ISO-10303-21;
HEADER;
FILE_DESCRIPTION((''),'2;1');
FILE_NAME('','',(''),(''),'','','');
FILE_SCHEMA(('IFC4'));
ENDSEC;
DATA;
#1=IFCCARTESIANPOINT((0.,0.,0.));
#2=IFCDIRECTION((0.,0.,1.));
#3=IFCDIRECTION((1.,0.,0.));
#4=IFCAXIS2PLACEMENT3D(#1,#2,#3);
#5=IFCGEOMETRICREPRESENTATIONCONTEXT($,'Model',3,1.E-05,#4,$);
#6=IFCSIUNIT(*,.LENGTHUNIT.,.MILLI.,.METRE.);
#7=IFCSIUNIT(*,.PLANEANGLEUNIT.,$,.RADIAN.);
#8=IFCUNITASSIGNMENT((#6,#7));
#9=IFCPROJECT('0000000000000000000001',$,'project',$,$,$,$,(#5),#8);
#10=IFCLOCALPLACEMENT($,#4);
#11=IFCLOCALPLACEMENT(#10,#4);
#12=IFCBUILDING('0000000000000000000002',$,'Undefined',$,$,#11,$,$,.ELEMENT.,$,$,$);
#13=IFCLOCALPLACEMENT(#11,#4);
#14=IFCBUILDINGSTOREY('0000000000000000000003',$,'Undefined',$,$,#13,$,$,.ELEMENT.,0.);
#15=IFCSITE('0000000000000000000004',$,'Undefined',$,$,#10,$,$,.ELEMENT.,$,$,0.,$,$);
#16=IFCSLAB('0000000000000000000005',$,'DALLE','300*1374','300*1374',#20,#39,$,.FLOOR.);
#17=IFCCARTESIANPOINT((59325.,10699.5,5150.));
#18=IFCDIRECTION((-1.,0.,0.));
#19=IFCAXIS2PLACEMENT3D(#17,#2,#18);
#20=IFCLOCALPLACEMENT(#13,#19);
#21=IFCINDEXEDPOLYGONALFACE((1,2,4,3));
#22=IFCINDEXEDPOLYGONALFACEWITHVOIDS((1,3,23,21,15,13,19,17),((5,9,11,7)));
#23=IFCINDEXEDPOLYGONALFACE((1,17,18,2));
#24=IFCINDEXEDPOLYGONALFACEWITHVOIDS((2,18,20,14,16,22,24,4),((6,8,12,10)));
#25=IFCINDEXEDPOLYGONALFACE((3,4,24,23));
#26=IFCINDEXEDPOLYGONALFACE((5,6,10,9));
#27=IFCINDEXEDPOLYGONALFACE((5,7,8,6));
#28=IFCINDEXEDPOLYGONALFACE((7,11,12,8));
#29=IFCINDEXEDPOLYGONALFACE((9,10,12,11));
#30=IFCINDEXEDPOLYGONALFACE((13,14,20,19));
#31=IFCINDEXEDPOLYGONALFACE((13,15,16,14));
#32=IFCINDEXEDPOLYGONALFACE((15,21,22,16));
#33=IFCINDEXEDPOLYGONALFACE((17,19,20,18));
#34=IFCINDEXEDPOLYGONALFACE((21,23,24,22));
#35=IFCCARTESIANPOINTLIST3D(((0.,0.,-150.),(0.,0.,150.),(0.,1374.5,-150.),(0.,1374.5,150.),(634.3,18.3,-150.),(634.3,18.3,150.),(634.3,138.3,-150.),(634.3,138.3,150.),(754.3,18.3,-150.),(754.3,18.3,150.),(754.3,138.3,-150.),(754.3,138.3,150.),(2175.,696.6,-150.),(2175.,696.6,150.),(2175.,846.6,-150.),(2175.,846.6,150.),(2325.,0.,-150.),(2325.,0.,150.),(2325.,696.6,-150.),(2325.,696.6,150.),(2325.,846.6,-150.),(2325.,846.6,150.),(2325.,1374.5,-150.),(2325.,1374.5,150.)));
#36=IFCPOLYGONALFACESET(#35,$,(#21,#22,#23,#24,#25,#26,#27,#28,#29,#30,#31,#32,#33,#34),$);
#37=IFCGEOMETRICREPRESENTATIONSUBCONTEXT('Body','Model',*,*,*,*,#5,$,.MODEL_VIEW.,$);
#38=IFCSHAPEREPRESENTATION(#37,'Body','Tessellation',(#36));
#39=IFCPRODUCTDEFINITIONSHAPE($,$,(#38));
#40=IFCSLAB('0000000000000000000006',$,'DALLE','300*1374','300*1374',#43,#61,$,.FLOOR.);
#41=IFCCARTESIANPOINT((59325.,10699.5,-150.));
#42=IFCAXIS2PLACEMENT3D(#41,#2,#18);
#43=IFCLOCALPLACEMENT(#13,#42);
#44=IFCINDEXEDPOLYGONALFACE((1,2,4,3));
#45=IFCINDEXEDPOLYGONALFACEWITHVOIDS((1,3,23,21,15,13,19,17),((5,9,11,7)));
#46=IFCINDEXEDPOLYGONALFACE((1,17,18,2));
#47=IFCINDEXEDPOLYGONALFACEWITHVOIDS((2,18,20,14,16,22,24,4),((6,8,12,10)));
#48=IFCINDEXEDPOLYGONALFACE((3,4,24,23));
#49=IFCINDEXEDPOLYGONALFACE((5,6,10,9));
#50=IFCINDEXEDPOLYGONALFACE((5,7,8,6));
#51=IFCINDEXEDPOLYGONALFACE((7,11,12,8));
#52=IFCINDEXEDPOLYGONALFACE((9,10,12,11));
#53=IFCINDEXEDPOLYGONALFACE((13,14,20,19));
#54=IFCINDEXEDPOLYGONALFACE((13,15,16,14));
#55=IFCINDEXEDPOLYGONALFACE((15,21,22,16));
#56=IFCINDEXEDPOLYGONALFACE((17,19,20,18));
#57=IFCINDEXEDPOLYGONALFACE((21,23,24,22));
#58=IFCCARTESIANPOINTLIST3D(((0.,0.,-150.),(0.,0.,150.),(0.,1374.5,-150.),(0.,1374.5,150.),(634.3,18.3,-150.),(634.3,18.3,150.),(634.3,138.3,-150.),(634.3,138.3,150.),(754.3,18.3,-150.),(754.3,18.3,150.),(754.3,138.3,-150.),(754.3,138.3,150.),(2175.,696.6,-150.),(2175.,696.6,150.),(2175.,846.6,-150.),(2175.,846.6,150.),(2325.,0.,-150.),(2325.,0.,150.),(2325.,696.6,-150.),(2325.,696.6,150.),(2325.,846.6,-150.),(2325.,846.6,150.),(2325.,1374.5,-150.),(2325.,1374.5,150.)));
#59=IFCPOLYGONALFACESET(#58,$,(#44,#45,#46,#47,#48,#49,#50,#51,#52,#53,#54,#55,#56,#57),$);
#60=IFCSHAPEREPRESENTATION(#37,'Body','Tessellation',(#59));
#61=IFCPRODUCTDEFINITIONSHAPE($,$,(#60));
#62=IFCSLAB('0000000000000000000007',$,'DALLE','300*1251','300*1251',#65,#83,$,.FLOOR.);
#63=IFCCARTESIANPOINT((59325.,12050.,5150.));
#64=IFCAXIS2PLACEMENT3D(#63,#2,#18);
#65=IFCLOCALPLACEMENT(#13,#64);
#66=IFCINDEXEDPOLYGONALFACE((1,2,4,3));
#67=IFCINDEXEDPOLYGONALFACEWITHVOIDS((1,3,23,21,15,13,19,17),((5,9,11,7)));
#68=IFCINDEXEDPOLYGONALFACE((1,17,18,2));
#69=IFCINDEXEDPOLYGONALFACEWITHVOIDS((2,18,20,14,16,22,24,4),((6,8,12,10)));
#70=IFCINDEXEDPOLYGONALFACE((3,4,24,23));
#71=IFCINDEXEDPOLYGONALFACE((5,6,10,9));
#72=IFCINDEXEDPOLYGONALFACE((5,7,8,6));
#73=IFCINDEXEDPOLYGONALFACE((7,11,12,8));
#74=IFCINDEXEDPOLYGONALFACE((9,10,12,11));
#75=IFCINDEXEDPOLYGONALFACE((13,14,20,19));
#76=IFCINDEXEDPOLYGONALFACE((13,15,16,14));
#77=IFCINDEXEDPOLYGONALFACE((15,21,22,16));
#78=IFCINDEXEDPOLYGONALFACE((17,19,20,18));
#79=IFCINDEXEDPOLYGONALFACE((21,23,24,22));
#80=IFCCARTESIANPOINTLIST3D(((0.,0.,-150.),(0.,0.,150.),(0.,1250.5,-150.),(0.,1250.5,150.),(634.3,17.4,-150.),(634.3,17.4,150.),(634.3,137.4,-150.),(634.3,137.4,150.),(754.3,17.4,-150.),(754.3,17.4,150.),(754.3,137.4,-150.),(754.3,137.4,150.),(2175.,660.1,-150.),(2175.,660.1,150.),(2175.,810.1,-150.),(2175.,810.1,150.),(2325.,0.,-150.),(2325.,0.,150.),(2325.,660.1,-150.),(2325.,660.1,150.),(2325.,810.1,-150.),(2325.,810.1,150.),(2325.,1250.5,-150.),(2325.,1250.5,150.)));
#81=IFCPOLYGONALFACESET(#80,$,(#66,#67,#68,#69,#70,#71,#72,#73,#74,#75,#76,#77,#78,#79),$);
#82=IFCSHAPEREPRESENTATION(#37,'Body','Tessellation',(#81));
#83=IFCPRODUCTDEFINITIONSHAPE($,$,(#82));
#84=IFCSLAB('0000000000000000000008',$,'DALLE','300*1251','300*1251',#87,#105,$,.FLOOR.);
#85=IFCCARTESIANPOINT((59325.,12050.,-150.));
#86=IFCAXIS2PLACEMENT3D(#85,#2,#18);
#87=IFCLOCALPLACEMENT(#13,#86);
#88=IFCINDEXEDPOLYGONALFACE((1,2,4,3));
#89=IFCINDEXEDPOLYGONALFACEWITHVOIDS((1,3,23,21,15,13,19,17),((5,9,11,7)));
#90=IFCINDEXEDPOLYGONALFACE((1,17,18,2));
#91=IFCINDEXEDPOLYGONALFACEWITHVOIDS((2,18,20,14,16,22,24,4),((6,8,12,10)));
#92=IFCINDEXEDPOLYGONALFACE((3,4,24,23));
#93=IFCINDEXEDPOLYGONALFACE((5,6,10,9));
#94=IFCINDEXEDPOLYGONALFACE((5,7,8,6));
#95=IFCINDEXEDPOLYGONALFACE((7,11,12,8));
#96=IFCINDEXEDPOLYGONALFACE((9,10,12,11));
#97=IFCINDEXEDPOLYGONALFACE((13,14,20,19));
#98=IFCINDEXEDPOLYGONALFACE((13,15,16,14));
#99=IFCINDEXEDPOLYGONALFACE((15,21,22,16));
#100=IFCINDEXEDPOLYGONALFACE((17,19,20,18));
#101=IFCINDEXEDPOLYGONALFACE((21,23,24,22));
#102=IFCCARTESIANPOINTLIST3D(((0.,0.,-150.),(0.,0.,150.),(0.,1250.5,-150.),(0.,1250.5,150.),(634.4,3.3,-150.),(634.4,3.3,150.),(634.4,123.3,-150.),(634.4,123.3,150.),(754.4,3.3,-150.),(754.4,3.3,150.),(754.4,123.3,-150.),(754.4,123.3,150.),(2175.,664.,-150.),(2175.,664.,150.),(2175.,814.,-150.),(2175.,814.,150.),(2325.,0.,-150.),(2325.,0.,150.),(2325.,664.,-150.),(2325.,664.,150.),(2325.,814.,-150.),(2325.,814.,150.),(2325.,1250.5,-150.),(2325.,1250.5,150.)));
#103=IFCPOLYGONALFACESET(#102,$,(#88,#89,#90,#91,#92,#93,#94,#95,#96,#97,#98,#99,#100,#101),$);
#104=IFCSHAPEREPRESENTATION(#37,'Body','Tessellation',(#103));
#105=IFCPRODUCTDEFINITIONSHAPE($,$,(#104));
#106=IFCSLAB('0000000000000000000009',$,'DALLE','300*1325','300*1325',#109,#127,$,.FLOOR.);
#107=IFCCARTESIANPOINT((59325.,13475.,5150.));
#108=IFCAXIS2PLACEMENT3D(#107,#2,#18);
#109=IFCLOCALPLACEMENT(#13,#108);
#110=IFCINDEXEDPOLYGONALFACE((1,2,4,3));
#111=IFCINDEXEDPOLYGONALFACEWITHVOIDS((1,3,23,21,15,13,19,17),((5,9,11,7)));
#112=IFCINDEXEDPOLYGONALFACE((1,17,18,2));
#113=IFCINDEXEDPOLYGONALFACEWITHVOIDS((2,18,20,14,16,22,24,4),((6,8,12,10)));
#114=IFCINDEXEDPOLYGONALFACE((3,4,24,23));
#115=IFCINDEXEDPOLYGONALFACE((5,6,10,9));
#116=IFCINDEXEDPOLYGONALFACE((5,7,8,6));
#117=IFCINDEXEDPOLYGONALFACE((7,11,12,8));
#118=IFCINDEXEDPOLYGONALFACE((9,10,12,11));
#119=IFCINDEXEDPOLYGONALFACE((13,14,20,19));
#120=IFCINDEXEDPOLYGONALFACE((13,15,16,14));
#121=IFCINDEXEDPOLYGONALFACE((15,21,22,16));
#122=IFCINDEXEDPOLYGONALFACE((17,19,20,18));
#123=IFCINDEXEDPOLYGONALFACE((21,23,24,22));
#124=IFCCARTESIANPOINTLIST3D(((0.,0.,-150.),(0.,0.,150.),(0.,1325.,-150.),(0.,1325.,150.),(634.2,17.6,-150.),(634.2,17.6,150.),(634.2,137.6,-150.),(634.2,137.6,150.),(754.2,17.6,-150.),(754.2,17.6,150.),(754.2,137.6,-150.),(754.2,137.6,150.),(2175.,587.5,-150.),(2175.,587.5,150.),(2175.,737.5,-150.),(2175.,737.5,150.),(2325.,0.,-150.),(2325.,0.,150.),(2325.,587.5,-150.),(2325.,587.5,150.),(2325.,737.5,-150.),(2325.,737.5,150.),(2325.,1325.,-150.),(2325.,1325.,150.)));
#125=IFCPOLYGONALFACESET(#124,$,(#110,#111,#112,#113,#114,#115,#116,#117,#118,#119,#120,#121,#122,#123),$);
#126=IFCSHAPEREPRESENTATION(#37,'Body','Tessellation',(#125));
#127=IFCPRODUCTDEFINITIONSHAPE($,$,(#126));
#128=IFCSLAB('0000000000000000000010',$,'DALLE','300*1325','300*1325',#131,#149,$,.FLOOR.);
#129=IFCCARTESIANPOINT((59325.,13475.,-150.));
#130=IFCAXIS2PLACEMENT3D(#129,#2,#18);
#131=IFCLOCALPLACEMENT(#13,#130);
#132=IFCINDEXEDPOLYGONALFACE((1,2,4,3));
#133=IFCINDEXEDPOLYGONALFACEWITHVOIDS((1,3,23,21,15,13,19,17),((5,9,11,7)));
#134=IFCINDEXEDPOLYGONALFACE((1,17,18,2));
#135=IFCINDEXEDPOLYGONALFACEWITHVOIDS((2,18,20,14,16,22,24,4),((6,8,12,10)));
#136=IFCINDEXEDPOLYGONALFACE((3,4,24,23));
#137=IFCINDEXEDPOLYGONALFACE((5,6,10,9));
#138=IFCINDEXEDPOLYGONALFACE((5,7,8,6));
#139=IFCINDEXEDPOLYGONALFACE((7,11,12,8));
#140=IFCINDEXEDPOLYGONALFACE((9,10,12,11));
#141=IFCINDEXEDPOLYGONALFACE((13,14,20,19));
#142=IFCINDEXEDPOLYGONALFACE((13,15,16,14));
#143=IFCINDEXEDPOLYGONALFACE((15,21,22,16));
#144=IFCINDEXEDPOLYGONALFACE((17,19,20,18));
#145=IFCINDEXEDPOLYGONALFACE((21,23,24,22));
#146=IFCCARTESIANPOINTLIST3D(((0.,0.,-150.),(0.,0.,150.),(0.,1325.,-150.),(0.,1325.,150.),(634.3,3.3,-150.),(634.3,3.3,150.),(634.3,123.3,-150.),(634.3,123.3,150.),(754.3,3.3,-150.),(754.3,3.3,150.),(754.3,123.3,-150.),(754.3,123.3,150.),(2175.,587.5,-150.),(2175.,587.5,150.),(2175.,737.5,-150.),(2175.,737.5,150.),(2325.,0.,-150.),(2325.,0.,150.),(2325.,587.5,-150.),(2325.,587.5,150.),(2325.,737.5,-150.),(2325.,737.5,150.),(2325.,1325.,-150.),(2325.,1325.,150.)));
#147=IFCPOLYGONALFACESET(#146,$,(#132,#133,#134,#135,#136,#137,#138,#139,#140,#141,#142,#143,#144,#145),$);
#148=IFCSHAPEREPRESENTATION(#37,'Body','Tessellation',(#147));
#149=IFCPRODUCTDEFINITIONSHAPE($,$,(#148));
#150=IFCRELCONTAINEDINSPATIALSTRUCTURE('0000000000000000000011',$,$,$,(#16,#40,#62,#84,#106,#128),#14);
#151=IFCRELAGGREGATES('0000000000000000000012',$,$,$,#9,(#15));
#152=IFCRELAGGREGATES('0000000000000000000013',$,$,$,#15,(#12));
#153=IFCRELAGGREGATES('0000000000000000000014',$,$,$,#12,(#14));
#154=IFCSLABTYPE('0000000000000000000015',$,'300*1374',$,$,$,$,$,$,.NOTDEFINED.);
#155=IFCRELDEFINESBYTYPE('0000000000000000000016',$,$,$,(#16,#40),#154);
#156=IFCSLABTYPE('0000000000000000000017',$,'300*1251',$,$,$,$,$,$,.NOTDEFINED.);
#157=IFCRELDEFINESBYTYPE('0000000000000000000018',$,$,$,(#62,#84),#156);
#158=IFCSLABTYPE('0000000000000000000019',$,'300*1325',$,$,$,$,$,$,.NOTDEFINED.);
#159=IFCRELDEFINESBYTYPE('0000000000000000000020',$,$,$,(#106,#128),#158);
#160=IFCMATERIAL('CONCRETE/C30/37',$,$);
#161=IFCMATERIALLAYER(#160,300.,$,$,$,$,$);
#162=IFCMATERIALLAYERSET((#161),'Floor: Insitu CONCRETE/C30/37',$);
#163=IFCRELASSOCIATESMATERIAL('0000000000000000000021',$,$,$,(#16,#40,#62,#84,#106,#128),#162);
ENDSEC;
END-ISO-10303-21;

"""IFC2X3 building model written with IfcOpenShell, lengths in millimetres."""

from ifc_helpers import new_model, si_unit, frame, origin_with_axes, origin_2d_with_axis, place, context, subcontext, project, spatial, polyline, rectangle, outline, extrude, boolean, material, layer, layer_set, layer_usage, type_object, element, save


model = new_model("IFC2X3")

# Units and contexts
model_context = context("Model", 3, precision=1e-05, world=origin_with_axes())
body_context = subcontext(model_context, "Body", "Model", "MODEL_VIEW")
ifc_project = project(units=[si_unit("LENGTHUNIT", "METRE", prefix="MILLI"), si_unit("PLANEANGLEUNIT", "RADIAN")], contexts=[model_context])

# Site, building, storey
site_placement = place(None, origin_with_axes())
site = spatial("IfcSite", under=ifc_project, at=site_placement, Name="Undefined", CompositionType="ELEMENT", RefElevation=0.0)
building_placement = place(site_placement, origin_with_axes())
building = spatial("IfcBuilding", under=site, at=building_placement, Name="Undefined", CompositionType="ELEMENT")
storey_placement = place(building_placement, origin_with_axes())
storey = spatial("IfcBuildingStorey", under=building, at=storey_placement, Name="Undefined", CompositionType="ELEMENT", Elevation=0.0)

# Slabs
ifc_material_1 = material(Name="CONCRETE/C30/37")
ifc_layer_1 = layer(ifc_material_1, 300.0)
ifc_layer_set_1 = layer_set([ifc_layer_1], Name="Floor: Insitu CONCRETE/C30/37")
ifc_layer_usage_1 = layer_usage(ifc_layer_set_1, "AXIS3", "POSITIVE", -150.0)
slab_type_1 = type_object("IfcSlabType", Name="300*1374", PredefinedType="NOTDEFINED")
slab_1_placement = place(storey_placement, frame((59325.0, 10699.5, 5150.0), z_axis=(0.0, 0.0, 1.0), x_axis=(-1.0, 0.0, 0.0)))
element("IfcSlab", 1, at=slab_1_placement, inside=storey, type_object=slab_type_1, material=ifc_layer_usage_1, Name="DALLE", Description="300*1374", ObjectType="300*1374", PredefinedType="FLOOR", context=body_context, shape_type="CSG", body=[
    boolean("DIFFERENCE", boolean("DIFFERENCE", extrude(outline(polyline([(0.0, 0.0), (2325.0, 0.0), (2325.0, 1374.5), (0.0, 1374.5), (0.0, 0.0)])), frame((0.0, 0.0, -150.0), z_axis=(0.0, 0.0, 1.0), x_axis=(1.0, 0.0, 0.0)), (0.0, 0.0, 1.0), 300.0), extrude(rectangle(XDim=150.0, YDim=150.0, at=origin_2d_with_axis()), frame((2250.0, 771.6, 160.0), z_axis=(0.0, 0.0, -1.0), x_axis=(-1.0, 0.0, 0.0)), (0.0, 0.0, 1.0), 320.0)), extrude(rectangle(XDim=120.0, YDim=120.0, at=origin_2d_with_axis()), frame((694.3, 78.3, 160.0), z_axis=(0.0, 0.0, -1.0), x_axis=(-1.0, 0.0, 0.0)), (0.0, 0.0, 1.0), 320.0)),
])
ifc_layer_usage_2 = layer_usage(ifc_layer_set_1, "AXIS3", "POSITIVE", -150.0)
slab_2_placement = place(storey_placement, frame((59325.0, 10699.5, -150.0), z_axis=(0.0, 0.0, 1.0), x_axis=(-1.0, 0.0, 0.0)))
element("IfcSlab", 2, at=slab_2_placement, inside=storey, type_object=slab_type_1, material=ifc_layer_usage_2, Name="DALLE", Description="300*1374", ObjectType="300*1374", PredefinedType="FLOOR", context=body_context, shape_type="CSG", body=[
    boolean("DIFFERENCE", boolean("DIFFERENCE", extrude(outline(polyline([(0.0, 0.0), (2325.0, 0.0), (2325.0, 1374.5), (0.0, 1374.5), (0.0, 0.0)])), frame((0.0, 0.0, -150.0), z_axis=(0.0, 0.0, 1.0), x_axis=(1.0, 0.0, 0.0)), (0.0, 0.0, 1.0), 300.0), extrude(rectangle(XDim=150.0, YDim=150.0, at=origin_2d_with_axis()), frame((2250.0, 771.6, 160.0), z_axis=(0.0, 0.0, -1.0), x_axis=(-1.0, 0.0, 0.0)), (0.0, 0.0, 1.0), 320.0)), extrude(rectangle(XDim=120.0, YDim=120.0, at=origin_2d_with_axis()), frame((694.3, 78.3, 160.0), z_axis=(0.0, 0.0, -1.0), x_axis=(-1.0, 0.0, 0.0)), (0.0, 0.0, 1.0), 320.0)),
])
ifc_layer_usage_3 = layer_usage(ifc_layer_set_1, "AXIS3", "POSITIVE", -150.0)
slab_type_2 = type_object("IfcSlabType", Name="300*1251", PredefinedType="NOTDEFINED")
slab_3_placement = place(storey_placement, frame((59325.0, 12050.0, 5150.0), z_axis=(0.0, 0.0, 1.0), x_axis=(-1.0, 0.0, 0.0)))
element("IfcSlab", 3, at=slab_3_placement, inside=storey, type_object=slab_type_2, material=ifc_layer_usage_3, Name="DALLE", Description="300*1251", ObjectType="300*1251", PredefinedType="FLOOR", context=body_context, shape_type="CSG", body=[
    boolean("DIFFERENCE", boolean("DIFFERENCE", extrude(outline(polyline([(0.0, 0.0), (2325.0, 0.0), (2325.0, 1250.5), (0.0, 1250.5), (0.0, 0.0)])), frame((0.0, 0.0, -150.0), z_axis=(0.0, 0.0, 1.0), x_axis=(1.0, 0.0, 0.0)), (0.0, 0.0, 1.0), 300.0), extrude(rectangle(XDim=150.0, YDim=150.0, at=origin_2d_with_axis()), frame((2250.0, 735.1, 160.0), z_axis=(0.0, 0.0, -1.0), x_axis=(-1.0, 0.0, 0.0)), (0.0, 0.0, 1.0), 320.0)), extrude(rectangle(XDim=120.0, YDim=120.0, at=origin_2d_with_axis()), frame((694.3, 77.4, 160.0), z_axis=(0.0, 0.0, -1.0), x_axis=(-1.0, 0.0, 0.0)), (0.0, 0.0, 1.0), 320.0)),
])
ifc_layer_usage_4 = layer_usage(ifc_layer_set_1, "AXIS3", "POSITIVE", -150.0)
slab_4_placement = place(storey_placement, frame((59325.0, 12050.0, -150.0), z_axis=(0.0, 0.0, 1.0), x_axis=(-1.0, 0.0, 0.0)))
element("IfcSlab", 4, at=slab_4_placement, inside=storey, type_object=slab_type_2, material=ifc_layer_usage_4, Name="DALLE", Description="300*1251", ObjectType="300*1251", PredefinedType="FLOOR", context=body_context, shape_type="CSG", body=[
    boolean("DIFFERENCE", boolean("DIFFERENCE", extrude(outline(polyline([(0.0, 0.0), (2325.0, 0.0), (2325.0, 1250.5), (0.0, 1250.5), (0.0, 0.0)])), frame((0.0, 0.0, -150.0), z_axis=(0.0, 0.0, 1.0), x_axis=(1.0, 0.0, 0.0)), (0.0, 0.0, 1.0), 300.0), extrude(rectangle(XDim=150.0, YDim=150.0, at=origin_2d_with_axis()), frame((2250.0, 739.0, 160.0), z_axis=(0.0, 0.0, -1.0), x_axis=(-1.0, 0.0, 0.0)), (0.0, 0.0, 1.0), 320.0)), extrude(rectangle(XDim=120.0, YDim=120.0, at=origin_2d_with_axis()), frame((694.4, 63.3, 160.0), z_axis=(0.0, 0.0, -1.0), x_axis=(-1.0, 0.0, 0.0)), (0.0, 0.0, 1.0), 320.0)),
])
ifc_layer_usage_5 = layer_usage(ifc_layer_set_1, "AXIS3", "POSITIVE", -150.0)
slab_type_3 = type_object("IfcSlabType", Name="300*1325", PredefinedType="NOTDEFINED")
slab_5_placement = place(storey_placement, frame((59325.0, 13475.0, 5150.0), z_axis=(0.0, 0.0, 1.0), x_axis=(-1.0, 0.0, 0.0)))
element("IfcSlab", 5, at=slab_5_placement, inside=storey, type_object=slab_type_3, material=ifc_layer_usage_5, Name="DALLE", Description="300*1325", ObjectType="300*1325", PredefinedType="FLOOR", context=body_context, shape_type="CSG", body=[
    boolean("DIFFERENCE", boolean("DIFFERENCE", boolean("DIFFERENCE", extrude(outline(polyline([(0.0, 0.0), (2325.0, 0.0), (2325.0, 1325.0), (0.0, 1325.0), (0.0, 0.0)])), frame((0.0, 0.0, -150.0), z_axis=(0.0, 0.0, 1.0), x_axis=(1.0, 0.0, 0.0)), (0.0, 0.0, 1.0), 300.0), extrude(rectangle(XDim=150.0, YDim=150.0, at=origin_2d_with_axis()), frame((2250.0, 662.5, 160.0), z_axis=(0.0, 0.0, -1.0), x_axis=(-1.0, 0.0, 0.0)), (0.0, 0.0, 1.0), 320.0)), extrude(rectangle(XDim=150.0, YDim=150.0, at=origin_2d_with_axis()), frame((2250.0, 662.5, 160.0), z_axis=(0.0, 0.0, -1.0), x_axis=(-1.0, 0.0, 0.0)), (0.0, 0.0, 1.0), 320.0)), extrude(rectangle(XDim=120.0, YDim=120.0, at=origin_2d_with_axis()), frame((694.2, 77.6, 160.0), z_axis=(0.0, 0.0, -1.0), x_axis=(-1.0, 0.0, 0.0)), (0.0, 0.0, 1.0), 320.0)),
])
ifc_layer_usage_6 = layer_usage(ifc_layer_set_1, "AXIS3", "POSITIVE", -150.0)
slab_6_placement = place(storey_placement, frame((59325.0, 13475.0, -150.0), z_axis=(0.0, 0.0, 1.0), x_axis=(-1.0, 0.0, 0.0)))
element("IfcSlab", 6, at=slab_6_placement, inside=storey, type_object=slab_type_3, material=ifc_layer_usage_6, Name="DALLE", Description="300*1325", ObjectType="300*1325", PredefinedType="FLOOR", context=body_context, shape_type="CSG", body=[
    boolean("DIFFERENCE", boolean("DIFFERENCE", extrude(outline(polyline([(0.0, 0.0), (2325.0, 0.0), (2325.0, 1325.0), (0.0, 1325.0), (0.0, 0.0)])), frame((0.0, 0.0, -150.0), z_axis=(0.0, 0.0, 1.0), x_axis=(1.0, 0.0, 0.0)), (0.0, 0.0, 1.0), 300.0), extrude(rectangle(XDim=150.0, YDim=150.0, at=origin_2d_with_axis()), frame((2250.0, 662.5, 160.0), z_axis=(0.0, 0.0, -1.0), x_axis=(-1.0, 0.0, 0.0)), (0.0, 0.0, 1.0), 320.0)), extrude(rectangle(XDim=120.0, YDim=120.0, at=origin_2d_with_axis()), frame((694.3, 63.3, 160.0), z_axis=(0.0, 0.0, -1.0), x_axis=(-1.0, 0.0, 0.0)), (0.0, 0.0, 1.0), 320.0)),
])

save(model, "model.ifc")
